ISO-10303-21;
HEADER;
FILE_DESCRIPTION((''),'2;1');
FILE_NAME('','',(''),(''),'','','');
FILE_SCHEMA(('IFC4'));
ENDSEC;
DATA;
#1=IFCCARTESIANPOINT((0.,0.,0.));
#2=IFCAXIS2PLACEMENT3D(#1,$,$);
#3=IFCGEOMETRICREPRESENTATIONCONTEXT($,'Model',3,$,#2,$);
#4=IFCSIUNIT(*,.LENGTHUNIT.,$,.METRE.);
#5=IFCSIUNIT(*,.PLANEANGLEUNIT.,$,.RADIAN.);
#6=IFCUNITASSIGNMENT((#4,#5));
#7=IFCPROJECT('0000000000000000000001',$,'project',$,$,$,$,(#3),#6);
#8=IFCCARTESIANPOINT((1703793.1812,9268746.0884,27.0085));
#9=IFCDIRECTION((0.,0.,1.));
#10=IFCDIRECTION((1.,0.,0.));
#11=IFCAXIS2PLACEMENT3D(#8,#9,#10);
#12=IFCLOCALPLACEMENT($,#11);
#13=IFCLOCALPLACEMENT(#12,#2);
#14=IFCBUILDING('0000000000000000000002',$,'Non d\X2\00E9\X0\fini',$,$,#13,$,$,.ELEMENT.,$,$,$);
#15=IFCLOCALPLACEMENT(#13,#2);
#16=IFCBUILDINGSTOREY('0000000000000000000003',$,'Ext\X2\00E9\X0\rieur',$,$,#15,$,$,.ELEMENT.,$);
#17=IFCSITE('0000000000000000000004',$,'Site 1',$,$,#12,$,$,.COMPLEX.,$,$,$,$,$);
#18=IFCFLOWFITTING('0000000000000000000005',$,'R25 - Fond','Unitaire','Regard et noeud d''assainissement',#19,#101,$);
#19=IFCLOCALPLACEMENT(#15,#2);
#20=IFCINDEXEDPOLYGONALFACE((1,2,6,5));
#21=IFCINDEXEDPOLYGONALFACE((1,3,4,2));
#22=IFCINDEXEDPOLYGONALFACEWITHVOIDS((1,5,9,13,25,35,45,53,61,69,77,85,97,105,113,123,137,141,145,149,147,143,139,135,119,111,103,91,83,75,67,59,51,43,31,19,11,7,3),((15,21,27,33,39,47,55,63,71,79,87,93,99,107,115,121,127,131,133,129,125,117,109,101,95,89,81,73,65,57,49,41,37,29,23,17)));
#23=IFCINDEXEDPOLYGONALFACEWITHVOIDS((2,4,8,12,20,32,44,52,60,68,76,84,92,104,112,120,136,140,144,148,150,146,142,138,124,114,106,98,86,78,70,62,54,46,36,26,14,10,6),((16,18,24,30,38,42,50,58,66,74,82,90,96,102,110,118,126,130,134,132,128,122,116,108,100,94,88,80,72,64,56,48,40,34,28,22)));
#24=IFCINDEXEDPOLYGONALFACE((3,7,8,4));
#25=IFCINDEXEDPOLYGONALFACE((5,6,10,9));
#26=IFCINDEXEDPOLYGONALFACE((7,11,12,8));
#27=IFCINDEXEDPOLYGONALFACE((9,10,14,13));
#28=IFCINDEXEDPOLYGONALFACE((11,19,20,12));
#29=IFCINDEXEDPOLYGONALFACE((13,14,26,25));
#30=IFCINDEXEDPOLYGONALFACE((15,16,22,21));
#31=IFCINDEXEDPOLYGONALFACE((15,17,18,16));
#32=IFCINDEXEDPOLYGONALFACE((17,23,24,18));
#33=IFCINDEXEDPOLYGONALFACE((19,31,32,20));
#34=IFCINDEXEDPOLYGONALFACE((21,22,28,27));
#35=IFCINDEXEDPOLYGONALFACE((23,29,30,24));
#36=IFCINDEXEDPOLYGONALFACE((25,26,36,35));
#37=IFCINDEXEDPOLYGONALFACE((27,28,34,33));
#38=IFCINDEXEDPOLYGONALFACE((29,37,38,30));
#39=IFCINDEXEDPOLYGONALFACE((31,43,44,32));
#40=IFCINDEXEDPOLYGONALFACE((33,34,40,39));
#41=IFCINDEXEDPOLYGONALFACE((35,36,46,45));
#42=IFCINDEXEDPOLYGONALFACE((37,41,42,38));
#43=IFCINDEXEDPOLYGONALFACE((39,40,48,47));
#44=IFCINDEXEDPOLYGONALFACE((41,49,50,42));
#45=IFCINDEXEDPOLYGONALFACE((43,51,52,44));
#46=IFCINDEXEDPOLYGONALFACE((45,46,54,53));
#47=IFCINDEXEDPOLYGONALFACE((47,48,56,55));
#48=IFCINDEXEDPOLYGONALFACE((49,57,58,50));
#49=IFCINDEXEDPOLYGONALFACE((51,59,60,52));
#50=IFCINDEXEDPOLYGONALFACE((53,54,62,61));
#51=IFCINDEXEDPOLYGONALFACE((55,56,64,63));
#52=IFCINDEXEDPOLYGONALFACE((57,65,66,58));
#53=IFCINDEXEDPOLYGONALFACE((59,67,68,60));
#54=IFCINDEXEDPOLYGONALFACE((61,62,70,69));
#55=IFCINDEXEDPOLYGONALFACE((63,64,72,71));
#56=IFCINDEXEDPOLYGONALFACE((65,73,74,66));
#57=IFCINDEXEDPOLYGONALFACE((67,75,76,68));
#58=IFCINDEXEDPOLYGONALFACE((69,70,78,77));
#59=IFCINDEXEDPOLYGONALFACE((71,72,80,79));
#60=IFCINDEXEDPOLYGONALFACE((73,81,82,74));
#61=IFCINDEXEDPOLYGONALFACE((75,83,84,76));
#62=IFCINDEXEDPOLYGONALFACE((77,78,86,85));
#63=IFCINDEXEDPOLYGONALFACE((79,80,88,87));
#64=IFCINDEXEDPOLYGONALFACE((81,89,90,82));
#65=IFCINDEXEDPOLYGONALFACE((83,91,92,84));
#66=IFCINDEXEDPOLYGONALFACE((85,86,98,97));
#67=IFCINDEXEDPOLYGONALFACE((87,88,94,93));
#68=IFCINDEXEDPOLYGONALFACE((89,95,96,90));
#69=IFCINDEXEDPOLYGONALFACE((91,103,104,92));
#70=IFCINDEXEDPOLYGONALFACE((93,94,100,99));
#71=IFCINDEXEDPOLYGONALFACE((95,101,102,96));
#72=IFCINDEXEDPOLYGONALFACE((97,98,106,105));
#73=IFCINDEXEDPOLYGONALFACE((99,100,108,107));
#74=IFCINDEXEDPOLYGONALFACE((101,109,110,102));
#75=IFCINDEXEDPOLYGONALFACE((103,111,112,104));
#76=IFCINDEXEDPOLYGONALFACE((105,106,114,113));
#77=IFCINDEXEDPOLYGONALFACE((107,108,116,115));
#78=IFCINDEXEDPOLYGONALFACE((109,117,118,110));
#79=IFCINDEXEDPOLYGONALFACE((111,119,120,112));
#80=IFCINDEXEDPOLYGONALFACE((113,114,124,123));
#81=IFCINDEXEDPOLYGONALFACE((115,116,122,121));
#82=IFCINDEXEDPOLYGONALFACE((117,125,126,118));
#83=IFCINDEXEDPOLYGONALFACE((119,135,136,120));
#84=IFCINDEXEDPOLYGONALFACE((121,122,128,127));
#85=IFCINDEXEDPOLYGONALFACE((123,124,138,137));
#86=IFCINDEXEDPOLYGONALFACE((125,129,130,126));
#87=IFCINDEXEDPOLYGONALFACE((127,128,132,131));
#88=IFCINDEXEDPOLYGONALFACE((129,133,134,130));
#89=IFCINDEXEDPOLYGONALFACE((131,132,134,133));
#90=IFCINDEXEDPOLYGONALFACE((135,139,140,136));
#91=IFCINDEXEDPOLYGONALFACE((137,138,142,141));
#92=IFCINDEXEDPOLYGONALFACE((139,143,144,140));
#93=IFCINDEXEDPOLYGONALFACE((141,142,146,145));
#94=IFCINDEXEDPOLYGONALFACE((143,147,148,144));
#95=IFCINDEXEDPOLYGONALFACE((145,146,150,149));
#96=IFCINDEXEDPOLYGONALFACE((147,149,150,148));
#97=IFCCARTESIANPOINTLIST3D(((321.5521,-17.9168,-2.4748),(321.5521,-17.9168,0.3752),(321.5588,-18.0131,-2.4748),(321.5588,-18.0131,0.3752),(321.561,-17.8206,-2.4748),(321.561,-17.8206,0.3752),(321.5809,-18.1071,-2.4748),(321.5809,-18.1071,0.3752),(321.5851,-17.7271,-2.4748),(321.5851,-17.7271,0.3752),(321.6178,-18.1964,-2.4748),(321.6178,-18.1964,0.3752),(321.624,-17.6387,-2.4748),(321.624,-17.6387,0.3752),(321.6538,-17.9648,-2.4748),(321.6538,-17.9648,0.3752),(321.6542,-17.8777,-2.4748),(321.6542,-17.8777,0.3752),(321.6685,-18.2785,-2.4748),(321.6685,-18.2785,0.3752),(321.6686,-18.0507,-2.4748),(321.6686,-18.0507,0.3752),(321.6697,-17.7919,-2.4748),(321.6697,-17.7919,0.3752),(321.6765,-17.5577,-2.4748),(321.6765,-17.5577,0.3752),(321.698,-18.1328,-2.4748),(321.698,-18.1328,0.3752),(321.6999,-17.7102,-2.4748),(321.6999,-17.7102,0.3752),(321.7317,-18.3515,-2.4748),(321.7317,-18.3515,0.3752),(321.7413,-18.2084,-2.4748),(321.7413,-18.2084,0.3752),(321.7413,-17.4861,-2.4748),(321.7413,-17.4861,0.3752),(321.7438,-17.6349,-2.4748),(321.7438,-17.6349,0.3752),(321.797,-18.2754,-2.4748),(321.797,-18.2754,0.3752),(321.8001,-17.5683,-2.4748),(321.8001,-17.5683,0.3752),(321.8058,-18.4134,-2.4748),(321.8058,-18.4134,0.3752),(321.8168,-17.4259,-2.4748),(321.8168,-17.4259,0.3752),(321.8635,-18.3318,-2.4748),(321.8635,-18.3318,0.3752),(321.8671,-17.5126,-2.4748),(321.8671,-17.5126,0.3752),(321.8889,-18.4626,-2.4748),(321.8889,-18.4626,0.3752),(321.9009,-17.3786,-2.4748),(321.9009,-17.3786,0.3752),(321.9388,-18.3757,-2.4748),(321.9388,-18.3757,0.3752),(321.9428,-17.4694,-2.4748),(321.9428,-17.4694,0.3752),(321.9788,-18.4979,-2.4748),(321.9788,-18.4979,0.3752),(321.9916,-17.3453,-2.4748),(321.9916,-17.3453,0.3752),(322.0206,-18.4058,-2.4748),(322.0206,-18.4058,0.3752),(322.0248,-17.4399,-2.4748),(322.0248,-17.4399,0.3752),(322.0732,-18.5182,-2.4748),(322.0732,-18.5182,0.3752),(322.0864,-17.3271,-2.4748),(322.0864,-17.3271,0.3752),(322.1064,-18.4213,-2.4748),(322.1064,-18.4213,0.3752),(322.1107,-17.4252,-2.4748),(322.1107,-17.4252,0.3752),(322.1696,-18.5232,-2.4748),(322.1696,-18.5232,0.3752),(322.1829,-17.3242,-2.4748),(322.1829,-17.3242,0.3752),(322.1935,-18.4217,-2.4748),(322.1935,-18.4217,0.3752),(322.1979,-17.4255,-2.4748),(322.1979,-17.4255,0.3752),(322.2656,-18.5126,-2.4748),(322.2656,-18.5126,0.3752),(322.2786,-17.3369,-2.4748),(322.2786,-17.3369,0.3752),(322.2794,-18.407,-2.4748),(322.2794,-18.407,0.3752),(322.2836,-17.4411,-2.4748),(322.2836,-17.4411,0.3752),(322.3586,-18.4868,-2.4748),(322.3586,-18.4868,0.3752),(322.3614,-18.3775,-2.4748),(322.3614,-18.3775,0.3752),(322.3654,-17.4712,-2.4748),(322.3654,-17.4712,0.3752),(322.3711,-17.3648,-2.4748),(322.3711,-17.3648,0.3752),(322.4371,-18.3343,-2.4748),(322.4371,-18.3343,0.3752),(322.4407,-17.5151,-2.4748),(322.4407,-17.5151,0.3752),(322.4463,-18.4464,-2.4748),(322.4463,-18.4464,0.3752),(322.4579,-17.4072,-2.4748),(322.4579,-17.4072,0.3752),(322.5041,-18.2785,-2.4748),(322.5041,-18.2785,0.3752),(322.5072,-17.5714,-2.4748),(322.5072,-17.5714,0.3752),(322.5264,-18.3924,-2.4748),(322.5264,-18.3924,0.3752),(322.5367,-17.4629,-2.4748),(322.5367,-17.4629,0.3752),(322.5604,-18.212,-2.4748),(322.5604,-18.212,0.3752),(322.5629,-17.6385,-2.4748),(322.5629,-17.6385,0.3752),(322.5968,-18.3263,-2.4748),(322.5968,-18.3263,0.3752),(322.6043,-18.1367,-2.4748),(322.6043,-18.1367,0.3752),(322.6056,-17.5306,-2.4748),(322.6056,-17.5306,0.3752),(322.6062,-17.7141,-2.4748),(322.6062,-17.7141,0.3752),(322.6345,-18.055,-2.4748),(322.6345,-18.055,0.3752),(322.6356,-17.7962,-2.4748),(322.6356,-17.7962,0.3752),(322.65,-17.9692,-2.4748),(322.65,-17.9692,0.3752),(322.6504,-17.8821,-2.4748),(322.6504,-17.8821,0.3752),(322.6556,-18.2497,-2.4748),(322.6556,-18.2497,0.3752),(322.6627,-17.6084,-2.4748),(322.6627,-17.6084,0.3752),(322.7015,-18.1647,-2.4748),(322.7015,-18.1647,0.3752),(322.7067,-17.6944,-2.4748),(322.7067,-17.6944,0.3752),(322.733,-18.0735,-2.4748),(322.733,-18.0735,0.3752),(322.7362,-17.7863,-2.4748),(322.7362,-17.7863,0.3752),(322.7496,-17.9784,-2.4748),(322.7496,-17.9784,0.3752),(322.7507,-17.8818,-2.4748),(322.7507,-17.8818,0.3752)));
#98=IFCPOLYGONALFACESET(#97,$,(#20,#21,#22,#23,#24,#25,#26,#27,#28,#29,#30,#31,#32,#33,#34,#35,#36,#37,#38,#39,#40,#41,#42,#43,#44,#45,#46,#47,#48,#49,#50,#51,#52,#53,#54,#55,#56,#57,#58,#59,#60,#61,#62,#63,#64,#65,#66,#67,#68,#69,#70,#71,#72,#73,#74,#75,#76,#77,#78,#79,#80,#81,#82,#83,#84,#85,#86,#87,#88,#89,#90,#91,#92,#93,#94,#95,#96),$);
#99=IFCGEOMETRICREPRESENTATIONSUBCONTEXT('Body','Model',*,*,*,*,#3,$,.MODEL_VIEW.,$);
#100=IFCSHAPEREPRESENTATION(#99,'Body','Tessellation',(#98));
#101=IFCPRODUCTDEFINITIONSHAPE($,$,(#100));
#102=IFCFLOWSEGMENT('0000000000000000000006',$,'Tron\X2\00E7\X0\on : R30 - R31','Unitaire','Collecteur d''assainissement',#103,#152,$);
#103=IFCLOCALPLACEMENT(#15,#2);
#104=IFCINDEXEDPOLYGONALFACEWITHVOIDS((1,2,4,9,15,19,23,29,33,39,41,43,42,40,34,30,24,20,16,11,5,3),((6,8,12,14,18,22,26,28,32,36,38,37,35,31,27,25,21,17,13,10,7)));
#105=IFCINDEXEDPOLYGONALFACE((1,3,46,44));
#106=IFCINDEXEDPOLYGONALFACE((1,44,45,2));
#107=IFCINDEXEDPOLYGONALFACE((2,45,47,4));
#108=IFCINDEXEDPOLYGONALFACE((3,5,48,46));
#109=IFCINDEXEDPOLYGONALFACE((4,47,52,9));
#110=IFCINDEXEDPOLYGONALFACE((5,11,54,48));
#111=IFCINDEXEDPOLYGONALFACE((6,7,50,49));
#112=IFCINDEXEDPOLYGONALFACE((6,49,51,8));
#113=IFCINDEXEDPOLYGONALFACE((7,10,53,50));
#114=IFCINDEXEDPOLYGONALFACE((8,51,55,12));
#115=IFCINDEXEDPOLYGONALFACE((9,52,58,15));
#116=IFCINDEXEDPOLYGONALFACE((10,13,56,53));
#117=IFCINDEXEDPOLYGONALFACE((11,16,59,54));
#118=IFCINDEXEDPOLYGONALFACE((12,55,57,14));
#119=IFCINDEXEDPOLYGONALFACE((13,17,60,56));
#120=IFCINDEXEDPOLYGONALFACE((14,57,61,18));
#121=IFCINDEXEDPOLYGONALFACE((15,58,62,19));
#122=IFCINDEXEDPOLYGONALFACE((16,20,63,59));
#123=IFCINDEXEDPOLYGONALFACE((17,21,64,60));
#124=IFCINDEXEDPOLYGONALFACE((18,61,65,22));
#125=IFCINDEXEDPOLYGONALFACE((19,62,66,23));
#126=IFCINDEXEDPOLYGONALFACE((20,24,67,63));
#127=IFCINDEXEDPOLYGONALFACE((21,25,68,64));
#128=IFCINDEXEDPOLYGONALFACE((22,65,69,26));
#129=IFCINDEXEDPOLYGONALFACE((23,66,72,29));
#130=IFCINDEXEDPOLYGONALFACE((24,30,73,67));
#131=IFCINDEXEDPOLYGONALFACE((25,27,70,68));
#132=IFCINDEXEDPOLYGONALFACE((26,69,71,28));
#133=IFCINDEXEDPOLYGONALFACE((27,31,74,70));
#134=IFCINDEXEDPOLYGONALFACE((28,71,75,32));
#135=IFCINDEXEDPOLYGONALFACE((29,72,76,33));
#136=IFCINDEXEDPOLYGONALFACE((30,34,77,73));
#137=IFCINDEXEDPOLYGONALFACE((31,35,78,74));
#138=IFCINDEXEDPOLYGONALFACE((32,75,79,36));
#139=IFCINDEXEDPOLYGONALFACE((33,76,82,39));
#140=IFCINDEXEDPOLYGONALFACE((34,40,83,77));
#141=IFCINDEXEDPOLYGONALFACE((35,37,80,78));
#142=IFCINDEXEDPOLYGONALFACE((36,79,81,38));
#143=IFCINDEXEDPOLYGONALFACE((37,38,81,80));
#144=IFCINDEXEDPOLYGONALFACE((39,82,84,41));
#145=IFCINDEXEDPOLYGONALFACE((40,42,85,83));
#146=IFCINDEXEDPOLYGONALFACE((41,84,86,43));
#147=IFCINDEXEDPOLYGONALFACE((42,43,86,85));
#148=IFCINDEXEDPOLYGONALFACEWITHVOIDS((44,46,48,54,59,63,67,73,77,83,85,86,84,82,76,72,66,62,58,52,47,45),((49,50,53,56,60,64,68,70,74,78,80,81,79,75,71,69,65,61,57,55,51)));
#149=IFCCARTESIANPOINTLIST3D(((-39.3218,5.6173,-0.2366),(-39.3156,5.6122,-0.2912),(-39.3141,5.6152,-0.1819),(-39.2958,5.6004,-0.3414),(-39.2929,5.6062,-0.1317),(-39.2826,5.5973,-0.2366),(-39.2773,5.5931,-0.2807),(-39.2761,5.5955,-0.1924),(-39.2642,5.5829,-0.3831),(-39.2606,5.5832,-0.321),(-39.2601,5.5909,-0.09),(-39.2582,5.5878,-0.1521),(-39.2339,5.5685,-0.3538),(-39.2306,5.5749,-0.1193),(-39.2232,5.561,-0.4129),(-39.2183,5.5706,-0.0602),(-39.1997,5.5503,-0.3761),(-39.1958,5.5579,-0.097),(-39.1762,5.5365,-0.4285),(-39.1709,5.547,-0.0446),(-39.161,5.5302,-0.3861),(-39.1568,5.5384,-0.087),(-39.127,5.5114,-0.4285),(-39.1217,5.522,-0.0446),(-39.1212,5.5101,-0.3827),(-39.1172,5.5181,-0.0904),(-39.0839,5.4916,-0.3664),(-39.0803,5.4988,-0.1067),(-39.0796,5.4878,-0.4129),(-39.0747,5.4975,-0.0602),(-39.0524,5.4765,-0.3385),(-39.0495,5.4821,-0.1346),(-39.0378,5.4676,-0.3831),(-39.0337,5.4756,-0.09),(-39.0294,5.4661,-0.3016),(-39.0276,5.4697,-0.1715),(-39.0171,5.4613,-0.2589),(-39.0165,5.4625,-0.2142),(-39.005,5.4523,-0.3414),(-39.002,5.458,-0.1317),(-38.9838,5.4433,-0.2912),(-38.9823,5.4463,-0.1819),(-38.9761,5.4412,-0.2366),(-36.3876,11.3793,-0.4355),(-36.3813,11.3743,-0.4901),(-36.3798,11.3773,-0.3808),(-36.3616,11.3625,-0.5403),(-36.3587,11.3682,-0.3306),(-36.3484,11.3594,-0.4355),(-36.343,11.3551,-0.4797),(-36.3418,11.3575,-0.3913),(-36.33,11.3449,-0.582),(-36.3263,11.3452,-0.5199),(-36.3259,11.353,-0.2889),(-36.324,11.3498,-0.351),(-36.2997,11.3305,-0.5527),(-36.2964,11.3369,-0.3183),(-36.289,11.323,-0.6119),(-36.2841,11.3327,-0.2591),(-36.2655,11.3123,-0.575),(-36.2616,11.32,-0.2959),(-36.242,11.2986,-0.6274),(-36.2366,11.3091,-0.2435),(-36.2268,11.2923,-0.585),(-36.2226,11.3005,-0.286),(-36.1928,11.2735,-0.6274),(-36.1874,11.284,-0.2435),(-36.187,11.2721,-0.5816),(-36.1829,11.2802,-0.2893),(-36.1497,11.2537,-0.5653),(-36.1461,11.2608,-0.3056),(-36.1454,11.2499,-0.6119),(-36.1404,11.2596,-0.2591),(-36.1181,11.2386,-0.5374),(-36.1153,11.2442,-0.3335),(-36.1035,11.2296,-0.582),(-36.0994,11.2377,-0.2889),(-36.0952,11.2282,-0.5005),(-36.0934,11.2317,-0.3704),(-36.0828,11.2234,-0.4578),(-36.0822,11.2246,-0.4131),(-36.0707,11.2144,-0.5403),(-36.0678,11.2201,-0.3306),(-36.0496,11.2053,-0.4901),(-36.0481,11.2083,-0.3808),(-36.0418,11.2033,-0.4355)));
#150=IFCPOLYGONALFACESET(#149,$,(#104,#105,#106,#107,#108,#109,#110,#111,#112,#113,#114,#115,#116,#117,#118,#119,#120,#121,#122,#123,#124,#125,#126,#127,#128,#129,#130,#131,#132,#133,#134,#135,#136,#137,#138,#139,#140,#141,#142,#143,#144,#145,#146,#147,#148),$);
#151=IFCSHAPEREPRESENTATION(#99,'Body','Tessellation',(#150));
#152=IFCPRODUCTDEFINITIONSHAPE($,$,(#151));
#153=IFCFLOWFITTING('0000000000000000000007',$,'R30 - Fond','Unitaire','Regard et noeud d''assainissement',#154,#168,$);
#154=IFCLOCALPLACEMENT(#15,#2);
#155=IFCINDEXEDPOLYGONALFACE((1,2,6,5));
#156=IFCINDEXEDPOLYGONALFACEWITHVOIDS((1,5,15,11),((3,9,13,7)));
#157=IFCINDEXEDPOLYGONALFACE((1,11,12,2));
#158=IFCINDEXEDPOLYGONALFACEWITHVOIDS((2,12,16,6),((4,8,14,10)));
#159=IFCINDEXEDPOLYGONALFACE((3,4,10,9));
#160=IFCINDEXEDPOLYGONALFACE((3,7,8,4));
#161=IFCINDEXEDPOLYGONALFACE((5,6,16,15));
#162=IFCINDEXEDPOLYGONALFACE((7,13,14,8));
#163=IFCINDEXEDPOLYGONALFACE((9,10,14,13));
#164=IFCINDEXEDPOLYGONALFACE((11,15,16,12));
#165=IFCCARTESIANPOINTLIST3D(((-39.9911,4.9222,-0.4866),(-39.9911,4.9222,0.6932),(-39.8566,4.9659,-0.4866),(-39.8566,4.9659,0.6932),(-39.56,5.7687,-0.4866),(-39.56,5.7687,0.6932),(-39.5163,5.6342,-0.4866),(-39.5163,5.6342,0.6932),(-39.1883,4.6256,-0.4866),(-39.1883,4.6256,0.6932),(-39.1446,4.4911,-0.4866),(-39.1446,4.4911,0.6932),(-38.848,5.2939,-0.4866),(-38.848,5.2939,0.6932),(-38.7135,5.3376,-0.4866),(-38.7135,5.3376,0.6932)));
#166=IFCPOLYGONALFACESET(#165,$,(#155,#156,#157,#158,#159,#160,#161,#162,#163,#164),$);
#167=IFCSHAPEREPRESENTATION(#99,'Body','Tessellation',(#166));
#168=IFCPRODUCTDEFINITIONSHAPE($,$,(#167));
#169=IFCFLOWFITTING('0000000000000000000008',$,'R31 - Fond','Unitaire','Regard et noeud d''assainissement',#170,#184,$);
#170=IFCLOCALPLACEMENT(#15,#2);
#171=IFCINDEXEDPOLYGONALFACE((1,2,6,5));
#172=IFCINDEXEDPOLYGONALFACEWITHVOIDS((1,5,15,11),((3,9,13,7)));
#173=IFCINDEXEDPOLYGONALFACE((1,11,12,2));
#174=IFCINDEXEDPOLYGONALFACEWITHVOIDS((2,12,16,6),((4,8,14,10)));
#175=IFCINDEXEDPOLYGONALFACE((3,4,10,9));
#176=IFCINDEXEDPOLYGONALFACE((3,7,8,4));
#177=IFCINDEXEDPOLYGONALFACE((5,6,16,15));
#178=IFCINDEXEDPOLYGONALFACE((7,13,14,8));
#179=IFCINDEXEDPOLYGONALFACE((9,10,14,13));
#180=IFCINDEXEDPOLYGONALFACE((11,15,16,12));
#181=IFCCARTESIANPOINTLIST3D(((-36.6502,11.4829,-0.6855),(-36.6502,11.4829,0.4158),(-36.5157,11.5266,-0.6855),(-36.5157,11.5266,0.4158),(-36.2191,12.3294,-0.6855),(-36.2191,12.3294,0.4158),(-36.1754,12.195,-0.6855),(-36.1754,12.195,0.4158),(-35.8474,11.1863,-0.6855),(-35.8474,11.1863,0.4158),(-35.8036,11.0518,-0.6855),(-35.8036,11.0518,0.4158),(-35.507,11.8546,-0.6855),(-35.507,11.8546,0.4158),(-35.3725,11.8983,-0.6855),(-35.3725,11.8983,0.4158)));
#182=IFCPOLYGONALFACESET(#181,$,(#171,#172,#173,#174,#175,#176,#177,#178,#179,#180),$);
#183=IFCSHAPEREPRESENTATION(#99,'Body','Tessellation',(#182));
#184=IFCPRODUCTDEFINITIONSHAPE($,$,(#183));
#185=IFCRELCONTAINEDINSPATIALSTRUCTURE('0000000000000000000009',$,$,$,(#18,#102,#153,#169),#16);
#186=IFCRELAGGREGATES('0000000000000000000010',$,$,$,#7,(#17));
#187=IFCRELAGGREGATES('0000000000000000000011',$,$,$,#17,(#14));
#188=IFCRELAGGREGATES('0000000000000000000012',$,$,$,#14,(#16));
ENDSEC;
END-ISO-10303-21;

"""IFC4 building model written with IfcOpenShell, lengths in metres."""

from ifc_helpers import new_model, si_unit, frame, origin, origin_2d, place, context, subcontext, project, spatial, hollow_rectangle, hollow_circle, extrude, element, save


model = new_model("IFC4")

# Units and contexts
model_context = context("Model", 3, world=origin())
body_context = subcontext(model_context, "Body", "Model", "MODEL_VIEW")
ifc_project = project(units=[si_unit("LENGTHUNIT", "METRE"), si_unit("PLANEANGLEUNIT", "RADIAN")], contexts=[model_context])

# Site, building, storey
site_placement = place(None, frame((1703793.1812, 9268746.0884, 27.0085), z_axis=(0.0, 0.0, 1.0), x_axis=(1.0, 0.0, 0.0)))
site = spatial("IfcSite", under=ifc_project, at=site_placement, Name="Site 1", CompositionType="COMPLEX")
building_placement = place(site_placement, origin())
building = spatial("IfcBuilding", under=site, at=building_placement, Name="Non défini", CompositionType="ELEMENT")
storey_placement = place(building_placement, origin())
storey = spatial("IfcBuildingStorey", under=building, at=storey_placement, Name="Extérieur", CompositionType="ELEMENT")

# Flow fitting
flow_fitting_1_placement = place(storey_placement, origin())
element("IfcFlowFitting", 1, at=flow_fitting_1_placement, inside=storey, Name="R25 - Fond", Description="Unitaire", ObjectType="Regard et noeud d'assainissement", context=body_context, shape_type="SweptSolid", body=[
    extrude(hollow_circle(Radius=0.6, WallThickness=0.1, at=origin_2d()), frame((322.1521, -17.9234, -2.4748), z_axis=(0.0, 0.0, 1.0), x_axis=(0.995803, -0.091517, 0.0)), (0.0, 0.0, 1.0), 2.85),
])

# Flow segment
flow_segment_1_placement = place(storey_placement, origin())
element("IfcFlowSegment", 2, at=flow_segment_1_placement, inside=storey, Name="Tronçon : R30 - R31", Description="Unitaire", ObjectType="Collecteur d'assainissement", context=body_context, shape_type="SweptSolid", body=[
    extrude(hollow_circle(Radius=0.194, WallThickness=0.044, at=origin_2d()), frame((-39.1489, 5.5292, -0.2366), z_axis=(0.45357, 0.89069, -0.030748), x_axis=(-0.891112, 0.453784, 0.0)), (0.0, 0.0, 1.0), 6.4692),
])

# Flow fittings
flow_fitting_2_placement = place(storey_placement, origin())
element("IfcFlowFitting", 3, at=flow_fitting_2_placement, inside=storey, Name="R30 - Fond", Description="Unitaire", ObjectType="Regard et noeud d'assainissement", context=body_context, shape_type="SweptSolid", body=[
    extrude(hollow_rectangle(XDim=0.95, YDim=0.95, WallThickness=0.1, at=origin_2d()), frame((-39.3523, 5.1299, -0.4866), z_axis=(0.0, 0.0, 1.0), x_axis=(0.453784, 0.891112, 0.0)), (0.0, 0.0, 1.0), 1.1798),
])
flow_fitting_3_placement = place(storey_placement, origin())
element("IfcFlowFitting", 4, at=flow_fitting_3_placement, inside=storey, Name="R31 - Fond", Description="Unitaire", ObjectType="Regard et noeud d'assainissement", context=body_context, shape_type="SweptSolid", body=[
    extrude(hollow_rectangle(XDim=0.95, YDim=0.95, WallThickness=0.1, at=origin_2d()), frame((-36.0114, 11.6906, -0.6855), z_axis=(0.0, 0.0, 1.0), x_axis=(0.453784, 0.891112, 0.0)), (0.0, 0.0, 1.0), 1.1012),
])

save(model, "model.ifc")
